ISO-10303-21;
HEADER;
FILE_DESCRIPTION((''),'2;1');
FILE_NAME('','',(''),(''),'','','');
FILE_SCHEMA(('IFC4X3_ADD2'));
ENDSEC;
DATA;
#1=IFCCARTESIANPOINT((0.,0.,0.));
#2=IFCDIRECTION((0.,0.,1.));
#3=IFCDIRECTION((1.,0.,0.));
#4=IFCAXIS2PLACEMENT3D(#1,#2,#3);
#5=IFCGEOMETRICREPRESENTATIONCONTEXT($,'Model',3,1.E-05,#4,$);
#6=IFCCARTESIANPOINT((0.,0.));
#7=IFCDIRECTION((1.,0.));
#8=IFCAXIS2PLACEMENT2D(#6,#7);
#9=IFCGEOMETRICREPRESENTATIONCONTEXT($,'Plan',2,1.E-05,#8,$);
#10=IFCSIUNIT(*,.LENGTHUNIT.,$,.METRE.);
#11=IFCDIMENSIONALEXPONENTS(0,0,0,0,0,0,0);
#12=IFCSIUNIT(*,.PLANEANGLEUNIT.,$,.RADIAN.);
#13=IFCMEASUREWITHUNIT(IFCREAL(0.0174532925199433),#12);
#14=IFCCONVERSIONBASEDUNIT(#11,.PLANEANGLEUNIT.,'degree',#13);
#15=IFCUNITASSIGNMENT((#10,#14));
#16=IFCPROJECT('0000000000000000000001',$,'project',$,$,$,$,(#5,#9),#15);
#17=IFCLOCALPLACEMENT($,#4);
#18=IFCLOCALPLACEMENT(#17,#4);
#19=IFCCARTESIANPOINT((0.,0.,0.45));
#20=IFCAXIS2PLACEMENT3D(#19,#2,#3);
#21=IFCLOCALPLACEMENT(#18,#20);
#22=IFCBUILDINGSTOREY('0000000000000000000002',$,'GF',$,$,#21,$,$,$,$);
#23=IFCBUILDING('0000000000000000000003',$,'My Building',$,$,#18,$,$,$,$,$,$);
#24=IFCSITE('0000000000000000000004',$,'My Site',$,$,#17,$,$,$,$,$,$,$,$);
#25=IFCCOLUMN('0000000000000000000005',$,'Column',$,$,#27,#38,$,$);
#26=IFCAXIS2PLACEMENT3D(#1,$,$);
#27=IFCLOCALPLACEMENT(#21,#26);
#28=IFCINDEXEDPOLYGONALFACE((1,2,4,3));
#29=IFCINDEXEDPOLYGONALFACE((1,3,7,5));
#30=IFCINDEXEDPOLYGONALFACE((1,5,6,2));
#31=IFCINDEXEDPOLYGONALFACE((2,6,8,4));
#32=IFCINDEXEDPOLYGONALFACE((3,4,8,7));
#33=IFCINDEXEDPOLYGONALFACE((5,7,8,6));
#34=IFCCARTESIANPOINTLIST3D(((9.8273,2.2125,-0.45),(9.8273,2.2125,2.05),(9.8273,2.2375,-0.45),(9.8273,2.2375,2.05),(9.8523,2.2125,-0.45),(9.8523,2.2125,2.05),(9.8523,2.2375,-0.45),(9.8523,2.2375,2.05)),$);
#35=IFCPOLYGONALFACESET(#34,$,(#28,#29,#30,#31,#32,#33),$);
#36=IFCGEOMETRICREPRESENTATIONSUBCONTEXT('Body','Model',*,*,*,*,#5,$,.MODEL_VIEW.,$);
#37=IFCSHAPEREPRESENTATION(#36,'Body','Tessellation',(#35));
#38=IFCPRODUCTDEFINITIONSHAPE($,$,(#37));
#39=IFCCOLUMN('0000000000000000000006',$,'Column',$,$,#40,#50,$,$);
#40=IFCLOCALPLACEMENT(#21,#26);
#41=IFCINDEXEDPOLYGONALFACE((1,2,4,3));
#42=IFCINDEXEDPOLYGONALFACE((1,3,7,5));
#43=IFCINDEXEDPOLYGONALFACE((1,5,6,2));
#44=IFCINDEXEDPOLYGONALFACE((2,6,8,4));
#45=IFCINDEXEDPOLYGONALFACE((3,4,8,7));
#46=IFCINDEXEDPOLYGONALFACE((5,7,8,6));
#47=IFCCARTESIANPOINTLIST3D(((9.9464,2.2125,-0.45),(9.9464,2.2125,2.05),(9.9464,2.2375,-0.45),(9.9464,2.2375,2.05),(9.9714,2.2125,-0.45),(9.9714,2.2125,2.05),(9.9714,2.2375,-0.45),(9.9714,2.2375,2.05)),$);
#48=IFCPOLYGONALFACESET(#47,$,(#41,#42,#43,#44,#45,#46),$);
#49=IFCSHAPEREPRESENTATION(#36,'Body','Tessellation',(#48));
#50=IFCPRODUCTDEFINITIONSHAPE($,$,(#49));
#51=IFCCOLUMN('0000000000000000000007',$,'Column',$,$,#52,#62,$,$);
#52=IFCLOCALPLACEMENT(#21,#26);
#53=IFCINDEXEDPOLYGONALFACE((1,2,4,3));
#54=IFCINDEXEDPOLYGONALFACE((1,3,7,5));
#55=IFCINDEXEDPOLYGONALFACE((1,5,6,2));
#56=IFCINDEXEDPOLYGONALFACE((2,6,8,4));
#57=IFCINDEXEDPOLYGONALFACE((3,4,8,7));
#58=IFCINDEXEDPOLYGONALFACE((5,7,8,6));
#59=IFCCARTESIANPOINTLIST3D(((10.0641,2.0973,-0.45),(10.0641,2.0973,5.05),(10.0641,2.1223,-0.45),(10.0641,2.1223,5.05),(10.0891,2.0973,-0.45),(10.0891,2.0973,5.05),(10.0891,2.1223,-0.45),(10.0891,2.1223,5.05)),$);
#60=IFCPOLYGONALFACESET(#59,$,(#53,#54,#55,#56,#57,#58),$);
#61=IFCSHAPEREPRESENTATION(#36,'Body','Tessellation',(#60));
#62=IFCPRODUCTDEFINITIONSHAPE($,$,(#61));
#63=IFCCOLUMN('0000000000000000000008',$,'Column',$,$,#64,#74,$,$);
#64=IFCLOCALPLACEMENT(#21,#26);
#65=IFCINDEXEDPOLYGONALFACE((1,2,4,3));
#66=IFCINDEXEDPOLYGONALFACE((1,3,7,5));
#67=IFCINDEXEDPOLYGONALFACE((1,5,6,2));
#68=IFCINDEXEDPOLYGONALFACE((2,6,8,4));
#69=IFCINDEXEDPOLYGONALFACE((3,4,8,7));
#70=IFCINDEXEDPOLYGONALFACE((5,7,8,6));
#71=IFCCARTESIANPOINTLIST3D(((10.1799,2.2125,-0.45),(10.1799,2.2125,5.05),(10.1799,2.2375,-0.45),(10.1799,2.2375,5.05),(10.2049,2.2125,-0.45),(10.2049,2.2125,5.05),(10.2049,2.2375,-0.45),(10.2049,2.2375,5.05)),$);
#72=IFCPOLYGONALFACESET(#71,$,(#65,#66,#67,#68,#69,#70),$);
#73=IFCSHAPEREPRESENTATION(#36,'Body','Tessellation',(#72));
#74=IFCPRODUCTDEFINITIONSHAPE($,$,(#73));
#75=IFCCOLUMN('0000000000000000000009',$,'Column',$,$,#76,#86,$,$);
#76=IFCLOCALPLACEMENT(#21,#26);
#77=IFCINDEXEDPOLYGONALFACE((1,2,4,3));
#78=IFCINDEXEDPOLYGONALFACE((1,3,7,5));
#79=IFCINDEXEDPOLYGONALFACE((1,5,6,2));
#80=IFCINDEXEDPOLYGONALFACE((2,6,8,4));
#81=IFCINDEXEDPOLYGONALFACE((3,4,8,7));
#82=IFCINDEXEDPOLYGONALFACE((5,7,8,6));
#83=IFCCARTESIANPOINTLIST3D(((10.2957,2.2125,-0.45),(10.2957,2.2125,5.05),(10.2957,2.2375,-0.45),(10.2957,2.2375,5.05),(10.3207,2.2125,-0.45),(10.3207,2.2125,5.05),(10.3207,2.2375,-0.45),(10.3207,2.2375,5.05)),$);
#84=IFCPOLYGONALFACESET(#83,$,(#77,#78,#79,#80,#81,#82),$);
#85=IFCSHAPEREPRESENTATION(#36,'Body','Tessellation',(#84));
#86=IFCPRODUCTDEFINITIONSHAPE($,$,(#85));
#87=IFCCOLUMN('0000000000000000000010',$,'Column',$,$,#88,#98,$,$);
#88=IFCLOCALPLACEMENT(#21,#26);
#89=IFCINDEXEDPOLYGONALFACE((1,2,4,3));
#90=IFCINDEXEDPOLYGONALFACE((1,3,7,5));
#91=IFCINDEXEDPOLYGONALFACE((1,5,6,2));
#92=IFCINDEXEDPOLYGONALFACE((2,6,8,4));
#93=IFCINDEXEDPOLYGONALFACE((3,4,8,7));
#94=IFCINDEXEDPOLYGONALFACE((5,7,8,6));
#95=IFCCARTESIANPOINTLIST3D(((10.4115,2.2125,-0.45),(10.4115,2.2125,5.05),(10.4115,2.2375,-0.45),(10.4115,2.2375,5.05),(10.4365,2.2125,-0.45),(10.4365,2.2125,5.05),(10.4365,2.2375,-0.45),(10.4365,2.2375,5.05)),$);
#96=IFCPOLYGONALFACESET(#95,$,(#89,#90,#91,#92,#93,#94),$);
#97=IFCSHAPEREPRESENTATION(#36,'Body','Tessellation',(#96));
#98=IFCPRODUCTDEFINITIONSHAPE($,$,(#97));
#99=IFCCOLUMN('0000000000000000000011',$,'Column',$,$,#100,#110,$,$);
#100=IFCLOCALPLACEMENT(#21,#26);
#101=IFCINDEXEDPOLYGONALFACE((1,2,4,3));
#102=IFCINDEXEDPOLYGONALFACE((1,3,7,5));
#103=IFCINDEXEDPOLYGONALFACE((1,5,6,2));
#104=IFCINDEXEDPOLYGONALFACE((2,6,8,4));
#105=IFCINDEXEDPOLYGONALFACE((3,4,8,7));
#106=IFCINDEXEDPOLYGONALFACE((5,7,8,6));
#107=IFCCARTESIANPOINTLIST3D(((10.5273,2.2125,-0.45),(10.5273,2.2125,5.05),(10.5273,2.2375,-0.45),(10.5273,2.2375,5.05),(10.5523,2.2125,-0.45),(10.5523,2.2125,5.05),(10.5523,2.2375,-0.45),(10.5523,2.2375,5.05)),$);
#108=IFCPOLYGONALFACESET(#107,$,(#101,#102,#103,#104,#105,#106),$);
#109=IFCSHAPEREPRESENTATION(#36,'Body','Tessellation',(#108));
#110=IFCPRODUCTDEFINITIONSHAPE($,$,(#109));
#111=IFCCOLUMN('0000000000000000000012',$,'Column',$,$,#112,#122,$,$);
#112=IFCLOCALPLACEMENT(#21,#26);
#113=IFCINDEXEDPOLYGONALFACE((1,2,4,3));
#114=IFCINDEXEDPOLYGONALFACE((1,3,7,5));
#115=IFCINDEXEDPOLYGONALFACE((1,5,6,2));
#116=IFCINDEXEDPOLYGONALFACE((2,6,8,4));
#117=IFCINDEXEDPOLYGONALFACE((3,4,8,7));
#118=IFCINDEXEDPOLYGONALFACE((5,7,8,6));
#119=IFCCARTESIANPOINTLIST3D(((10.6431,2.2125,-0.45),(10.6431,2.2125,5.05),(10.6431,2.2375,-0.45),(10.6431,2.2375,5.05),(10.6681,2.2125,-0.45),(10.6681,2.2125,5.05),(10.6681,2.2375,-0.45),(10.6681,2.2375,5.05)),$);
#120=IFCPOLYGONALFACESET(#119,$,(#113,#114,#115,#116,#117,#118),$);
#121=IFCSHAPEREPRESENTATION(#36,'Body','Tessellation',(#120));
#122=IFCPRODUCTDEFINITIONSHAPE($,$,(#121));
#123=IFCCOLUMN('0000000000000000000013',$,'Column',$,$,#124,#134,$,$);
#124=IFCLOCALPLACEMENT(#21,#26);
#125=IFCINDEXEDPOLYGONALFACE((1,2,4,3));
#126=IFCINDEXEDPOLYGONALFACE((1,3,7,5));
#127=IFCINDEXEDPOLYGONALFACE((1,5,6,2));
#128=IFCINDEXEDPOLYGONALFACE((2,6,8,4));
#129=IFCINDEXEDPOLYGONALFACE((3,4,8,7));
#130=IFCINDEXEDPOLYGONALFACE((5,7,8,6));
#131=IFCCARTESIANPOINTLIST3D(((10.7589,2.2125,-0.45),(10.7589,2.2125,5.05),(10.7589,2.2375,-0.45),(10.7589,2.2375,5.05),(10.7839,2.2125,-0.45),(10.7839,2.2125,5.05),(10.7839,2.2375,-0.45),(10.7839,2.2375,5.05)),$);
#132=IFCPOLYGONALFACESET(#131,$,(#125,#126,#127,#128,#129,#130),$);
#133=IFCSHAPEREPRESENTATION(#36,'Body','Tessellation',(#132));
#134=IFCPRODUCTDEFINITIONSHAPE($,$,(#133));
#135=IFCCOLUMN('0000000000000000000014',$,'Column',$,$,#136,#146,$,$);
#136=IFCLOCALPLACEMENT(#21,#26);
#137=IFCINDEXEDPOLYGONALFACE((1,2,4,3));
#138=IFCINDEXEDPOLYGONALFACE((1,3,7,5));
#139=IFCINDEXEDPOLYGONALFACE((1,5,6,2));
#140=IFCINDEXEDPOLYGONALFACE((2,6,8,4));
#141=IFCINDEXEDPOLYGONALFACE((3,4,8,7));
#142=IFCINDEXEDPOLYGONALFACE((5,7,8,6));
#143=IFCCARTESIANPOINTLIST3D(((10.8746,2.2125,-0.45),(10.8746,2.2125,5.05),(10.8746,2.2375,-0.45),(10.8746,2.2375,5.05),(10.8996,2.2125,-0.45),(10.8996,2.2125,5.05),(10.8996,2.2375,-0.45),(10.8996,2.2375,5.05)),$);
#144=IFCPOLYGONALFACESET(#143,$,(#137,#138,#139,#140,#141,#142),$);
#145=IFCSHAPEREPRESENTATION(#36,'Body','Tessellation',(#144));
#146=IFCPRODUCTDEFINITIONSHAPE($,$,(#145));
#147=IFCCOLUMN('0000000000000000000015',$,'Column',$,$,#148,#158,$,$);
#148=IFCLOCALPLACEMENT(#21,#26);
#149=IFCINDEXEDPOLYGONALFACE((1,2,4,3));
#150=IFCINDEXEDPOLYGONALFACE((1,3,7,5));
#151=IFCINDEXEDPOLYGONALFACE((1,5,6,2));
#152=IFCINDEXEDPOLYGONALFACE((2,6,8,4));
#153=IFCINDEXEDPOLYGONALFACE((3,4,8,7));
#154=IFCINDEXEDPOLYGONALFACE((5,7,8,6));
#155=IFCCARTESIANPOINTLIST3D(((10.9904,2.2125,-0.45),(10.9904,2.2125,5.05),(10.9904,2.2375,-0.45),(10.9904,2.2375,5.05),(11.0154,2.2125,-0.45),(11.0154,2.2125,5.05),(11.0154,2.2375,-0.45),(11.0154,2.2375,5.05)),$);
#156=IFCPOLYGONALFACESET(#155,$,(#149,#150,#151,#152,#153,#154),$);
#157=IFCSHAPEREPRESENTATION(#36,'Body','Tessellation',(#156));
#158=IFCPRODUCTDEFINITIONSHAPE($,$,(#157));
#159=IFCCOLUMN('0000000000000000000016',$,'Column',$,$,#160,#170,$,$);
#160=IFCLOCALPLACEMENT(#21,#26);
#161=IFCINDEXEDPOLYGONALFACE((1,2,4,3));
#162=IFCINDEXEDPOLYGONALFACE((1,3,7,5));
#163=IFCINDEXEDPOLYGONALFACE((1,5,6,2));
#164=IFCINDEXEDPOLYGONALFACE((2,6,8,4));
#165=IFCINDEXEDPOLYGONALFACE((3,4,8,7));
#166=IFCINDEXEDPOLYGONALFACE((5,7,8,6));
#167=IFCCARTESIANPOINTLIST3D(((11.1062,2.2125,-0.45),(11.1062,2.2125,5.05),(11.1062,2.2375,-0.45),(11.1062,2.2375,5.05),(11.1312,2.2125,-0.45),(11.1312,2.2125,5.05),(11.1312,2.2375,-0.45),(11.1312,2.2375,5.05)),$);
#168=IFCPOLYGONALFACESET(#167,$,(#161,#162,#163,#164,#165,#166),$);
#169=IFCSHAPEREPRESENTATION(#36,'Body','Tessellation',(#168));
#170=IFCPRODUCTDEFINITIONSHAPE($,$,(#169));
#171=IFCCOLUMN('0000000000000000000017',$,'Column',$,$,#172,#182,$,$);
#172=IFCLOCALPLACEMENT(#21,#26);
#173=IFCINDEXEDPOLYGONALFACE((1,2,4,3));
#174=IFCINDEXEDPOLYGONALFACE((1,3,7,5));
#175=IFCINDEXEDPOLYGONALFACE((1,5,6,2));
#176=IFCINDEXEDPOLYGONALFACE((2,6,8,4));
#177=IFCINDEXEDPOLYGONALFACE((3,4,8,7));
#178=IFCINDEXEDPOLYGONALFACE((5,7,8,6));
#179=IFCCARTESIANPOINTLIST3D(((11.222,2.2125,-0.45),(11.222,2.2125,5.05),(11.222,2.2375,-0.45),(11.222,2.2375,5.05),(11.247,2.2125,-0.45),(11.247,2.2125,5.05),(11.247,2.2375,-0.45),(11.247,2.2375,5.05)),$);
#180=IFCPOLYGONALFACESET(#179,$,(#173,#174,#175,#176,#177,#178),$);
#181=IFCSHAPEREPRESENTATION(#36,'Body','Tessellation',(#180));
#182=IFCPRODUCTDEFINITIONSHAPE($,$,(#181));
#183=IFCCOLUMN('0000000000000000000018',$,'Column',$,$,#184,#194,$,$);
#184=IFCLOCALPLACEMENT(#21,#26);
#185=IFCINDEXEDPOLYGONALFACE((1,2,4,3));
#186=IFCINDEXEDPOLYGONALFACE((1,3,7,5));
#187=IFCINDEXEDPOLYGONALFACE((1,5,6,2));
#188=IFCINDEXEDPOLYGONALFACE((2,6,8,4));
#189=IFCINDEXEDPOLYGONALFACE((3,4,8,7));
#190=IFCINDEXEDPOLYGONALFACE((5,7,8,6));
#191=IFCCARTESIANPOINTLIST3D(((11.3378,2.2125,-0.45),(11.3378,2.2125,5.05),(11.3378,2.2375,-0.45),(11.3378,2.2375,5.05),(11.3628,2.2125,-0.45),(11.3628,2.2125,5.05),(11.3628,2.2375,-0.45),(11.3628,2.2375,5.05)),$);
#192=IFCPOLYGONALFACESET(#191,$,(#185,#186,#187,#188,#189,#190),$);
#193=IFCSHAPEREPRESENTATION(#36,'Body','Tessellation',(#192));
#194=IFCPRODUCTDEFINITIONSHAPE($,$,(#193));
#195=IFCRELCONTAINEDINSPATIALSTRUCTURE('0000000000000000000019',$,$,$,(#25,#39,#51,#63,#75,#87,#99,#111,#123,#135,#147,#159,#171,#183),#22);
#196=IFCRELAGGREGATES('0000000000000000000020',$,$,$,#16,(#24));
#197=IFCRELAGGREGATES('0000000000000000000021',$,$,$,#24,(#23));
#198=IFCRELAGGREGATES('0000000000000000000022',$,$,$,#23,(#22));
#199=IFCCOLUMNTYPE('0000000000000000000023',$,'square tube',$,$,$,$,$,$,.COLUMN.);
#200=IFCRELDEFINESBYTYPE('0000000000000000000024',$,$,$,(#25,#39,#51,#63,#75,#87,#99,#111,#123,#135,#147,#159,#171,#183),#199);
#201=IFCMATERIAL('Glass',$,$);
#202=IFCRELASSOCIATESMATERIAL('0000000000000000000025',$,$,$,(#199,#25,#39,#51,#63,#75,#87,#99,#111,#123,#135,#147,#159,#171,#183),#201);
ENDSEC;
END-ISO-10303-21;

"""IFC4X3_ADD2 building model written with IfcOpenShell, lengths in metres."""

from ifc_helpers import new_model, entity, si_unit, converted_unit, frame, origin_with_axes, origin_2d_with_axis, place, context, subcontext, project, spatial, rectangle, extrude, material, material_profile, profile_set, profile_usage, type_object, element, save


model = new_model("IFC4X3_ADD2")

# Units and contexts
model_context = context("Model", 3, precision=1e-05, world=origin_with_axes())
plan_context = context("Plan", 2, precision=1e-05, world=origin_2d_with_axis())
body_context_1 = subcontext(model_context, "Body", "Model", "MODEL_VIEW")
ifc_project = project(units=[si_unit("LENGTHUNIT", "METRE"), converted_unit("PLANEANGLEUNIT", "degree", entity("IfcReal", 0.0174532925199433), si_unit("PLANEANGLEUNIT", "RADIAN"), dimensions=[0, 0, 0, 0, 0, 0, 0])], contexts=[model_context, plan_context])

# Site, building, storey
site_placement = place(None, origin_with_axes())
site = spatial("IfcSite", under=ifc_project, at=site_placement, Name="My Site")
building_placement = place(site_placement, origin_with_axes())
building = spatial("IfcBuilding", under=site, at=building_placement, Name="My Building")
storey_placement = place(building_placement, frame((0.0, 0.0, 0.45), z_axis=(0.0, 0.0, 1.0), x_axis=(1.0, 0.0, 0.0)))
storey = spatial("IfcBuildingStorey", under=building, at=storey_placement, Name="GF")

# Columns
ifc_material_1 = material(Name="Glass")
ifc_material_profile = material_profile(ifc_material_1, rectangle(XDim=0.025, YDim=0.025))
ifc_profile_set = profile_set([ifc_material_profile])
column_type = type_object("IfcColumnType", Name="square tube", PredefinedType="COLUMN", material=ifc_profile_set)
ifc_profile_usage_1 = profile_usage(ifc_profile_set, cardinal=5)
column_1_placement = place(storey_placement, frame((9.8398, 2.225, -0.45), z_axis=(0.0, 0.0, 1.0), x_axis=(1.0, 0.0, 0.0)))
element("IfcColumn", 1, at=column_1_placement, inside=storey, type_object=column_type, material=ifc_profile_usage_1, Name="Column", context=body_context_1, shape_type="SweptSolid", body=[
    extrude(rectangle(XDim=0.025, YDim=0.025), origin_with_axes(), (0.0, 0.0, 1.0), 2.5),
])
ifc_profile_usage_2 = profile_usage(ifc_profile_set, cardinal=5)
column_2_placement = place(storey_placement, frame((9.9589, 2.225, -0.45), z_axis=(0.0, 0.0, 1.0), x_axis=(1.0, 0.0, 0.0)))
element("IfcColumn", 2, at=column_2_placement, inside=storey, type_object=column_type, material=ifc_profile_usage_2, Name="Column", context=body_context_1, shape_type="SweptSolid", body=[
    extrude(rectangle(XDim=0.025, YDim=0.025), origin_with_axes(), (0.0, 0.0, 1.0), 2.5),
])
ifc_profile_usage_3 = profile_usage(ifc_profile_set, cardinal=5)
column_3_placement = place(storey_placement, frame((10.0766, 2.1098, -0.45), z_axis=(0.0, 0.0, 1.0), x_axis=(1.0, 0.0, 0.0)))
element("IfcColumn", 3, at=column_3_placement, inside=storey, type_object=column_type, material=ifc_profile_usage_3, Name="Column", context=body_context_1, shape_type="SweptSolid", body=[
    extrude(rectangle(XDim=0.025, YDim=0.025), origin_with_axes(), (0.0, 0.0, 1.0), 5.5),
])
ifc_profile_usage_4 = profile_usage(ifc_profile_set, cardinal=5)
column_4_placement = place(storey_placement, frame((10.1924, 2.225, -0.45), z_axis=(0.0, 0.0, 1.0), x_axis=(1.0, 0.0, 0.0)))
element("IfcColumn", 4, at=column_4_placement, inside=storey, type_object=column_type, material=ifc_profile_usage_4, Name="Column", context=body_context_1, shape_type="SweptSolid", body=[
    extrude(rectangle(XDim=0.025, YDim=0.025), origin_with_axes(), (0.0, 0.0, 1.0), 5.5),
])
ifc_profile_usage_5 = profile_usage(ifc_profile_set, cardinal=5)
column_5_placement = place(storey_placement, frame((10.3082, 2.225, -0.45), z_axis=(0.0, 0.0, 1.0), x_axis=(1.0, 0.0, 0.0)))
element("IfcColumn", 5, at=column_5_placement, inside=storey, type_object=column_type, material=ifc_profile_usage_5, Name="Column", context=body_context_1, shape_type="SweptSolid", body=[
    extrude(rectangle(XDim=0.025, YDim=0.025), origin_with_axes(), (0.0, 0.0, 1.0), 5.5),
])
ifc_profile_usage_6 = profile_usage(ifc_profile_set, cardinal=5)
column_6_placement = place(storey_placement, frame((10.424, 2.225, -0.45), z_axis=(0.0, 0.0, 1.0), x_axis=(1.0, 0.0, 0.0)))
element("IfcColumn", 6, at=column_6_placement, inside=storey, type_object=column_type, material=ifc_profile_usage_6, Name="Column", context=body_context_1, shape_type="SweptSolid", body=[
    extrude(rectangle(XDim=0.025, YDim=0.025), origin_with_axes(), (0.0, 0.0, 1.0), 5.5),
])
ifc_profile_usage_7 = profile_usage(ifc_profile_set, cardinal=5)
column_7_placement = place(storey_placement, frame((10.5398, 2.225, -0.45), z_axis=(0.0, 0.0, 1.0), x_axis=(1.0, 0.0, 0.0)))
element("IfcColumn", 7, at=column_7_placement, inside=storey, type_object=column_type, material=ifc_profile_usage_7, Name="Column", context=body_context_1, shape_type="SweptSolid", body=[
    extrude(rectangle(XDim=0.025, YDim=0.025), origin_with_axes(), (0.0, 0.0, 1.0), 5.5),
])
ifc_profile_usage_8 = profile_usage(ifc_profile_set, cardinal=5)
column_8_placement = place(storey_placement, frame((10.6556, 2.225, -0.45), z_axis=(0.0, 0.0, 1.0), x_axis=(1.0, 0.0, 0.0)))
element("IfcColumn", 8, at=column_8_placement, inside=storey, type_object=column_type, material=ifc_profile_usage_8, Name="Column", context=body_context_1, shape_type="SweptSolid", body=[
    extrude(rectangle(XDim=0.025, YDim=0.025), origin_with_axes(), (0.0, 0.0, 1.0), 5.5),
])
ifc_profile_usage_9 = profile_usage(ifc_profile_set, cardinal=5)
column_9_placement = place(storey_placement, frame((10.7714, 2.225, -0.45), z_axis=(0.0, 0.0, 1.0), x_axis=(1.0, 0.0, 0.0)))
element("IfcColumn", 9, at=column_9_placement, inside=storey, type_object=column_type, material=ifc_profile_usage_9, Name="Column", context=body_context_1, shape_type="SweptSolid", body=[
    extrude(rectangle(XDim=0.025, YDim=0.025), origin_with_axes(), (0.0, 0.0, 1.0), 5.5),
])
ifc_profile_usage_10 = profile_usage(ifc_profile_set, cardinal=5)
column_10_placement = place(storey_placement, frame((10.8871, 2.225, -0.45), z_axis=(0.0, 0.0, 1.0), x_axis=(1.0, 0.0, 0.0)))
element("IfcColumn", 10, at=column_10_placement, inside=storey, type_object=column_type, material=ifc_profile_usage_10, Name="Column", context=body_context_1, shape_type="SweptSolid", body=[
    extrude(rectangle(XDim=0.025, YDim=0.025), origin_with_axes(), (0.0, 0.0, 1.0), 5.5),
])
ifc_profile_usage_11 = profile_usage(ifc_profile_set, cardinal=5)
column_11_placement = place(storey_placement, frame((11.0029, 2.225, -0.45), z_axis=(0.0, 0.0, 1.0), x_axis=(1.0, 0.0, 0.0)))
element("IfcColumn", 11, at=column_11_placement, inside=storey, type_object=column_type, material=ifc_profile_usage_11, Name="Column", context=body_context_1, shape_type="SweptSolid", body=[
    extrude(rectangle(XDim=0.025, YDim=0.025), origin_with_axes(), (0.0, 0.0, 1.0), 5.5),
])
ifc_profile_usage_12 = profile_usage(ifc_profile_set, cardinal=5)
column_12_placement = place(storey_placement, frame((11.1187, 2.225, -0.45), z_axis=(0.0, 0.0, 1.0), x_axis=(1.0, 0.0, 0.0)))
element("IfcColumn", 12, at=column_12_placement, inside=storey, type_object=column_type, material=ifc_profile_usage_12, Name="Column", context=body_context_1, shape_type="SweptSolid", body=[
    extrude(rectangle(XDim=0.025, YDim=0.025), origin_with_axes(), (0.0, 0.0, 1.0), 5.5),
])
ifc_profile_usage_13 = profile_usage(ifc_profile_set, cardinal=5)
column_13_placement = place(storey_placement, frame((11.2345, 2.225, -0.45), z_axis=(0.0, 0.0, 1.0), x_axis=(1.0, 0.0, 0.0)))
element("IfcColumn", 13, at=column_13_placement, inside=storey, type_object=column_type, material=ifc_profile_usage_13, Name="Column", context=body_context_1, shape_type="SweptSolid", body=[
    extrude(rectangle(XDim=0.025, YDim=0.025), origin_with_axes(), (0.0, 0.0, 1.0), 5.5),
])
ifc_profile_usage_14 = profile_usage(ifc_profile_set, cardinal=5)
column_14_placement = place(storey_placement, frame((11.3503, 2.225, -0.45), z_axis=(0.0, 0.0, 1.0), x_axis=(1.0, 0.0, 0.0)))
element("IfcColumn", 14, at=column_14_placement, inside=storey, type_object=column_type, material=ifc_profile_usage_14, Name="Column", context=body_context_1, shape_type="SweptSolid", body=[
    extrude(rectangle(XDim=0.025, YDim=0.025), origin_with_axes(), (0.0, 0.0, 1.0), 5.5),
])

save(model, "model.ifc")
